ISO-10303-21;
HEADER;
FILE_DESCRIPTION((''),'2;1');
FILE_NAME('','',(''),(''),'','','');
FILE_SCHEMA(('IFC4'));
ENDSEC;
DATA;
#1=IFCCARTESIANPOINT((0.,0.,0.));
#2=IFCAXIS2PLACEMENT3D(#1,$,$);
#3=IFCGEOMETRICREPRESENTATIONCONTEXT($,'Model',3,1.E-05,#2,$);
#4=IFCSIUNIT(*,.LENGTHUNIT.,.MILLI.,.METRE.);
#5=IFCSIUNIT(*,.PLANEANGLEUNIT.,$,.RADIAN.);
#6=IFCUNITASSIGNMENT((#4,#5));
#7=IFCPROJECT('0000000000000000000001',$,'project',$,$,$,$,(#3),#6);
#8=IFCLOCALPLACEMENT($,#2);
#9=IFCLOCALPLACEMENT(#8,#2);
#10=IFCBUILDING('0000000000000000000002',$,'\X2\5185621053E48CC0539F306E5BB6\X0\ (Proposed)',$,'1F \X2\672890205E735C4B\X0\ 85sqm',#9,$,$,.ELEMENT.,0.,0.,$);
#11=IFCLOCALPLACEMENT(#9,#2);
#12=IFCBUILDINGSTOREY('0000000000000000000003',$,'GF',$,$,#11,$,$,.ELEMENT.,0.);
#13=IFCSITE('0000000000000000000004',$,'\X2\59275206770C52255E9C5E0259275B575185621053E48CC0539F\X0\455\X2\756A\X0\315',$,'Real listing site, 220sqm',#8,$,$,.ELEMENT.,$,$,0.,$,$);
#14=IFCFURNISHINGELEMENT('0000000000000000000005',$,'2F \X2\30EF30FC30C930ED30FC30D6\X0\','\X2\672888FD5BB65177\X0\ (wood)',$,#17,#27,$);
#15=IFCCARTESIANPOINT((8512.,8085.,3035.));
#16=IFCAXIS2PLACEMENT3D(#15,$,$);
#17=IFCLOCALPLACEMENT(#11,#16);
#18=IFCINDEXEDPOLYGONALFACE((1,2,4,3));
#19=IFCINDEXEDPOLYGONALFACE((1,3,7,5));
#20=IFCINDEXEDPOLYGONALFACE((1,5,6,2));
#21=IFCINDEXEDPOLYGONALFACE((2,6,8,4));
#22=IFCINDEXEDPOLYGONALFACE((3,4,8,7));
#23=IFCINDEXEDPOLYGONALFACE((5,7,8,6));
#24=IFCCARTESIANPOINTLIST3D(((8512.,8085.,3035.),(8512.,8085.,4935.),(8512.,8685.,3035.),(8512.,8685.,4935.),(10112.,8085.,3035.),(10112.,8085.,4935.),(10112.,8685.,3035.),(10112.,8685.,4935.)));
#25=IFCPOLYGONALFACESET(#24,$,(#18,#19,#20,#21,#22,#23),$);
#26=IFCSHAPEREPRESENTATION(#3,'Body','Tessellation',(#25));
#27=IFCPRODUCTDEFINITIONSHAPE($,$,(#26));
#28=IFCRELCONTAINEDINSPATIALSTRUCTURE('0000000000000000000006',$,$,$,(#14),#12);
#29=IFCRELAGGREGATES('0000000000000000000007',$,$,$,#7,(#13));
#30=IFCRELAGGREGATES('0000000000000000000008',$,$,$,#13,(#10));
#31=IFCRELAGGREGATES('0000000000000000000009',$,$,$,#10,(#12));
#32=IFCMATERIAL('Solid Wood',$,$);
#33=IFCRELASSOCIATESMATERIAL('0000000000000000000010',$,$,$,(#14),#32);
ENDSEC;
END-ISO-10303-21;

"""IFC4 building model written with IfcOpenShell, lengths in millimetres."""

from ifc_helpers import new_model, si_unit, frame, frame_2d, origin, place, context, project, spatial, rectangle, extrude, material, element, save


model = new_model("IFC4")

# Units and contexts
model_context = context("Model", 3, precision=1e-05, world=origin())
ifc_project = project(units=[si_unit("LENGTHUNIT", "METRE", prefix="MILLI"), si_unit("PLANEANGLEUNIT", "RADIAN")], contexts=[model_context])

# Site, building, storey
site_placement = place(None, origin())
site = spatial("IfcSite", under=ifc_project, at=site_placement, Name="大分県別府市大字内成古賀原455番315", ObjectType="Real listing site, 220sqm", CompositionType="ELEMENT", RefElevation=0.0)
building_placement = place(site_placement, origin())
building = spatial("IfcBuilding", under=site, at=building_placement, Name="内成古賀原の家 (Proposed)", ObjectType="1F 木造平屋 85sqm", CompositionType="ELEMENT", ElevationOfRefHeight=0.0, ElevationOfTerrain=0.0)
storey_placement = place(building_placement, origin())
storey = spatial("IfcBuildingStorey", under=building, at=storey_placement, Name="GF", CompositionType="ELEMENT", Elevation=0.0)

# Shared definitions
ifc_material_1 = material(Name="Solid Wood")

# Furnishing element
furnishing_1_placement = place(storey_placement, frame((8512.0, 8085.0, 3035.0)))
element("IfcFurnishingElement", 1, at=furnishing_1_placement, inside=storey, material=ifc_material_1, Name="2F ワードローブ", Description="木製家具 (wood)", context=model_context, shape_type="SweptSolid", body=[
    extrude(rectangle(XDim=1600.0, YDim=600.0, at=frame_2d((800.0, 300.0))), frame((8512.0, 8085.0, 3035.0)), (0.0, 0.0, 1.0), 1900.0),
])

save(model, "model.ifc")
